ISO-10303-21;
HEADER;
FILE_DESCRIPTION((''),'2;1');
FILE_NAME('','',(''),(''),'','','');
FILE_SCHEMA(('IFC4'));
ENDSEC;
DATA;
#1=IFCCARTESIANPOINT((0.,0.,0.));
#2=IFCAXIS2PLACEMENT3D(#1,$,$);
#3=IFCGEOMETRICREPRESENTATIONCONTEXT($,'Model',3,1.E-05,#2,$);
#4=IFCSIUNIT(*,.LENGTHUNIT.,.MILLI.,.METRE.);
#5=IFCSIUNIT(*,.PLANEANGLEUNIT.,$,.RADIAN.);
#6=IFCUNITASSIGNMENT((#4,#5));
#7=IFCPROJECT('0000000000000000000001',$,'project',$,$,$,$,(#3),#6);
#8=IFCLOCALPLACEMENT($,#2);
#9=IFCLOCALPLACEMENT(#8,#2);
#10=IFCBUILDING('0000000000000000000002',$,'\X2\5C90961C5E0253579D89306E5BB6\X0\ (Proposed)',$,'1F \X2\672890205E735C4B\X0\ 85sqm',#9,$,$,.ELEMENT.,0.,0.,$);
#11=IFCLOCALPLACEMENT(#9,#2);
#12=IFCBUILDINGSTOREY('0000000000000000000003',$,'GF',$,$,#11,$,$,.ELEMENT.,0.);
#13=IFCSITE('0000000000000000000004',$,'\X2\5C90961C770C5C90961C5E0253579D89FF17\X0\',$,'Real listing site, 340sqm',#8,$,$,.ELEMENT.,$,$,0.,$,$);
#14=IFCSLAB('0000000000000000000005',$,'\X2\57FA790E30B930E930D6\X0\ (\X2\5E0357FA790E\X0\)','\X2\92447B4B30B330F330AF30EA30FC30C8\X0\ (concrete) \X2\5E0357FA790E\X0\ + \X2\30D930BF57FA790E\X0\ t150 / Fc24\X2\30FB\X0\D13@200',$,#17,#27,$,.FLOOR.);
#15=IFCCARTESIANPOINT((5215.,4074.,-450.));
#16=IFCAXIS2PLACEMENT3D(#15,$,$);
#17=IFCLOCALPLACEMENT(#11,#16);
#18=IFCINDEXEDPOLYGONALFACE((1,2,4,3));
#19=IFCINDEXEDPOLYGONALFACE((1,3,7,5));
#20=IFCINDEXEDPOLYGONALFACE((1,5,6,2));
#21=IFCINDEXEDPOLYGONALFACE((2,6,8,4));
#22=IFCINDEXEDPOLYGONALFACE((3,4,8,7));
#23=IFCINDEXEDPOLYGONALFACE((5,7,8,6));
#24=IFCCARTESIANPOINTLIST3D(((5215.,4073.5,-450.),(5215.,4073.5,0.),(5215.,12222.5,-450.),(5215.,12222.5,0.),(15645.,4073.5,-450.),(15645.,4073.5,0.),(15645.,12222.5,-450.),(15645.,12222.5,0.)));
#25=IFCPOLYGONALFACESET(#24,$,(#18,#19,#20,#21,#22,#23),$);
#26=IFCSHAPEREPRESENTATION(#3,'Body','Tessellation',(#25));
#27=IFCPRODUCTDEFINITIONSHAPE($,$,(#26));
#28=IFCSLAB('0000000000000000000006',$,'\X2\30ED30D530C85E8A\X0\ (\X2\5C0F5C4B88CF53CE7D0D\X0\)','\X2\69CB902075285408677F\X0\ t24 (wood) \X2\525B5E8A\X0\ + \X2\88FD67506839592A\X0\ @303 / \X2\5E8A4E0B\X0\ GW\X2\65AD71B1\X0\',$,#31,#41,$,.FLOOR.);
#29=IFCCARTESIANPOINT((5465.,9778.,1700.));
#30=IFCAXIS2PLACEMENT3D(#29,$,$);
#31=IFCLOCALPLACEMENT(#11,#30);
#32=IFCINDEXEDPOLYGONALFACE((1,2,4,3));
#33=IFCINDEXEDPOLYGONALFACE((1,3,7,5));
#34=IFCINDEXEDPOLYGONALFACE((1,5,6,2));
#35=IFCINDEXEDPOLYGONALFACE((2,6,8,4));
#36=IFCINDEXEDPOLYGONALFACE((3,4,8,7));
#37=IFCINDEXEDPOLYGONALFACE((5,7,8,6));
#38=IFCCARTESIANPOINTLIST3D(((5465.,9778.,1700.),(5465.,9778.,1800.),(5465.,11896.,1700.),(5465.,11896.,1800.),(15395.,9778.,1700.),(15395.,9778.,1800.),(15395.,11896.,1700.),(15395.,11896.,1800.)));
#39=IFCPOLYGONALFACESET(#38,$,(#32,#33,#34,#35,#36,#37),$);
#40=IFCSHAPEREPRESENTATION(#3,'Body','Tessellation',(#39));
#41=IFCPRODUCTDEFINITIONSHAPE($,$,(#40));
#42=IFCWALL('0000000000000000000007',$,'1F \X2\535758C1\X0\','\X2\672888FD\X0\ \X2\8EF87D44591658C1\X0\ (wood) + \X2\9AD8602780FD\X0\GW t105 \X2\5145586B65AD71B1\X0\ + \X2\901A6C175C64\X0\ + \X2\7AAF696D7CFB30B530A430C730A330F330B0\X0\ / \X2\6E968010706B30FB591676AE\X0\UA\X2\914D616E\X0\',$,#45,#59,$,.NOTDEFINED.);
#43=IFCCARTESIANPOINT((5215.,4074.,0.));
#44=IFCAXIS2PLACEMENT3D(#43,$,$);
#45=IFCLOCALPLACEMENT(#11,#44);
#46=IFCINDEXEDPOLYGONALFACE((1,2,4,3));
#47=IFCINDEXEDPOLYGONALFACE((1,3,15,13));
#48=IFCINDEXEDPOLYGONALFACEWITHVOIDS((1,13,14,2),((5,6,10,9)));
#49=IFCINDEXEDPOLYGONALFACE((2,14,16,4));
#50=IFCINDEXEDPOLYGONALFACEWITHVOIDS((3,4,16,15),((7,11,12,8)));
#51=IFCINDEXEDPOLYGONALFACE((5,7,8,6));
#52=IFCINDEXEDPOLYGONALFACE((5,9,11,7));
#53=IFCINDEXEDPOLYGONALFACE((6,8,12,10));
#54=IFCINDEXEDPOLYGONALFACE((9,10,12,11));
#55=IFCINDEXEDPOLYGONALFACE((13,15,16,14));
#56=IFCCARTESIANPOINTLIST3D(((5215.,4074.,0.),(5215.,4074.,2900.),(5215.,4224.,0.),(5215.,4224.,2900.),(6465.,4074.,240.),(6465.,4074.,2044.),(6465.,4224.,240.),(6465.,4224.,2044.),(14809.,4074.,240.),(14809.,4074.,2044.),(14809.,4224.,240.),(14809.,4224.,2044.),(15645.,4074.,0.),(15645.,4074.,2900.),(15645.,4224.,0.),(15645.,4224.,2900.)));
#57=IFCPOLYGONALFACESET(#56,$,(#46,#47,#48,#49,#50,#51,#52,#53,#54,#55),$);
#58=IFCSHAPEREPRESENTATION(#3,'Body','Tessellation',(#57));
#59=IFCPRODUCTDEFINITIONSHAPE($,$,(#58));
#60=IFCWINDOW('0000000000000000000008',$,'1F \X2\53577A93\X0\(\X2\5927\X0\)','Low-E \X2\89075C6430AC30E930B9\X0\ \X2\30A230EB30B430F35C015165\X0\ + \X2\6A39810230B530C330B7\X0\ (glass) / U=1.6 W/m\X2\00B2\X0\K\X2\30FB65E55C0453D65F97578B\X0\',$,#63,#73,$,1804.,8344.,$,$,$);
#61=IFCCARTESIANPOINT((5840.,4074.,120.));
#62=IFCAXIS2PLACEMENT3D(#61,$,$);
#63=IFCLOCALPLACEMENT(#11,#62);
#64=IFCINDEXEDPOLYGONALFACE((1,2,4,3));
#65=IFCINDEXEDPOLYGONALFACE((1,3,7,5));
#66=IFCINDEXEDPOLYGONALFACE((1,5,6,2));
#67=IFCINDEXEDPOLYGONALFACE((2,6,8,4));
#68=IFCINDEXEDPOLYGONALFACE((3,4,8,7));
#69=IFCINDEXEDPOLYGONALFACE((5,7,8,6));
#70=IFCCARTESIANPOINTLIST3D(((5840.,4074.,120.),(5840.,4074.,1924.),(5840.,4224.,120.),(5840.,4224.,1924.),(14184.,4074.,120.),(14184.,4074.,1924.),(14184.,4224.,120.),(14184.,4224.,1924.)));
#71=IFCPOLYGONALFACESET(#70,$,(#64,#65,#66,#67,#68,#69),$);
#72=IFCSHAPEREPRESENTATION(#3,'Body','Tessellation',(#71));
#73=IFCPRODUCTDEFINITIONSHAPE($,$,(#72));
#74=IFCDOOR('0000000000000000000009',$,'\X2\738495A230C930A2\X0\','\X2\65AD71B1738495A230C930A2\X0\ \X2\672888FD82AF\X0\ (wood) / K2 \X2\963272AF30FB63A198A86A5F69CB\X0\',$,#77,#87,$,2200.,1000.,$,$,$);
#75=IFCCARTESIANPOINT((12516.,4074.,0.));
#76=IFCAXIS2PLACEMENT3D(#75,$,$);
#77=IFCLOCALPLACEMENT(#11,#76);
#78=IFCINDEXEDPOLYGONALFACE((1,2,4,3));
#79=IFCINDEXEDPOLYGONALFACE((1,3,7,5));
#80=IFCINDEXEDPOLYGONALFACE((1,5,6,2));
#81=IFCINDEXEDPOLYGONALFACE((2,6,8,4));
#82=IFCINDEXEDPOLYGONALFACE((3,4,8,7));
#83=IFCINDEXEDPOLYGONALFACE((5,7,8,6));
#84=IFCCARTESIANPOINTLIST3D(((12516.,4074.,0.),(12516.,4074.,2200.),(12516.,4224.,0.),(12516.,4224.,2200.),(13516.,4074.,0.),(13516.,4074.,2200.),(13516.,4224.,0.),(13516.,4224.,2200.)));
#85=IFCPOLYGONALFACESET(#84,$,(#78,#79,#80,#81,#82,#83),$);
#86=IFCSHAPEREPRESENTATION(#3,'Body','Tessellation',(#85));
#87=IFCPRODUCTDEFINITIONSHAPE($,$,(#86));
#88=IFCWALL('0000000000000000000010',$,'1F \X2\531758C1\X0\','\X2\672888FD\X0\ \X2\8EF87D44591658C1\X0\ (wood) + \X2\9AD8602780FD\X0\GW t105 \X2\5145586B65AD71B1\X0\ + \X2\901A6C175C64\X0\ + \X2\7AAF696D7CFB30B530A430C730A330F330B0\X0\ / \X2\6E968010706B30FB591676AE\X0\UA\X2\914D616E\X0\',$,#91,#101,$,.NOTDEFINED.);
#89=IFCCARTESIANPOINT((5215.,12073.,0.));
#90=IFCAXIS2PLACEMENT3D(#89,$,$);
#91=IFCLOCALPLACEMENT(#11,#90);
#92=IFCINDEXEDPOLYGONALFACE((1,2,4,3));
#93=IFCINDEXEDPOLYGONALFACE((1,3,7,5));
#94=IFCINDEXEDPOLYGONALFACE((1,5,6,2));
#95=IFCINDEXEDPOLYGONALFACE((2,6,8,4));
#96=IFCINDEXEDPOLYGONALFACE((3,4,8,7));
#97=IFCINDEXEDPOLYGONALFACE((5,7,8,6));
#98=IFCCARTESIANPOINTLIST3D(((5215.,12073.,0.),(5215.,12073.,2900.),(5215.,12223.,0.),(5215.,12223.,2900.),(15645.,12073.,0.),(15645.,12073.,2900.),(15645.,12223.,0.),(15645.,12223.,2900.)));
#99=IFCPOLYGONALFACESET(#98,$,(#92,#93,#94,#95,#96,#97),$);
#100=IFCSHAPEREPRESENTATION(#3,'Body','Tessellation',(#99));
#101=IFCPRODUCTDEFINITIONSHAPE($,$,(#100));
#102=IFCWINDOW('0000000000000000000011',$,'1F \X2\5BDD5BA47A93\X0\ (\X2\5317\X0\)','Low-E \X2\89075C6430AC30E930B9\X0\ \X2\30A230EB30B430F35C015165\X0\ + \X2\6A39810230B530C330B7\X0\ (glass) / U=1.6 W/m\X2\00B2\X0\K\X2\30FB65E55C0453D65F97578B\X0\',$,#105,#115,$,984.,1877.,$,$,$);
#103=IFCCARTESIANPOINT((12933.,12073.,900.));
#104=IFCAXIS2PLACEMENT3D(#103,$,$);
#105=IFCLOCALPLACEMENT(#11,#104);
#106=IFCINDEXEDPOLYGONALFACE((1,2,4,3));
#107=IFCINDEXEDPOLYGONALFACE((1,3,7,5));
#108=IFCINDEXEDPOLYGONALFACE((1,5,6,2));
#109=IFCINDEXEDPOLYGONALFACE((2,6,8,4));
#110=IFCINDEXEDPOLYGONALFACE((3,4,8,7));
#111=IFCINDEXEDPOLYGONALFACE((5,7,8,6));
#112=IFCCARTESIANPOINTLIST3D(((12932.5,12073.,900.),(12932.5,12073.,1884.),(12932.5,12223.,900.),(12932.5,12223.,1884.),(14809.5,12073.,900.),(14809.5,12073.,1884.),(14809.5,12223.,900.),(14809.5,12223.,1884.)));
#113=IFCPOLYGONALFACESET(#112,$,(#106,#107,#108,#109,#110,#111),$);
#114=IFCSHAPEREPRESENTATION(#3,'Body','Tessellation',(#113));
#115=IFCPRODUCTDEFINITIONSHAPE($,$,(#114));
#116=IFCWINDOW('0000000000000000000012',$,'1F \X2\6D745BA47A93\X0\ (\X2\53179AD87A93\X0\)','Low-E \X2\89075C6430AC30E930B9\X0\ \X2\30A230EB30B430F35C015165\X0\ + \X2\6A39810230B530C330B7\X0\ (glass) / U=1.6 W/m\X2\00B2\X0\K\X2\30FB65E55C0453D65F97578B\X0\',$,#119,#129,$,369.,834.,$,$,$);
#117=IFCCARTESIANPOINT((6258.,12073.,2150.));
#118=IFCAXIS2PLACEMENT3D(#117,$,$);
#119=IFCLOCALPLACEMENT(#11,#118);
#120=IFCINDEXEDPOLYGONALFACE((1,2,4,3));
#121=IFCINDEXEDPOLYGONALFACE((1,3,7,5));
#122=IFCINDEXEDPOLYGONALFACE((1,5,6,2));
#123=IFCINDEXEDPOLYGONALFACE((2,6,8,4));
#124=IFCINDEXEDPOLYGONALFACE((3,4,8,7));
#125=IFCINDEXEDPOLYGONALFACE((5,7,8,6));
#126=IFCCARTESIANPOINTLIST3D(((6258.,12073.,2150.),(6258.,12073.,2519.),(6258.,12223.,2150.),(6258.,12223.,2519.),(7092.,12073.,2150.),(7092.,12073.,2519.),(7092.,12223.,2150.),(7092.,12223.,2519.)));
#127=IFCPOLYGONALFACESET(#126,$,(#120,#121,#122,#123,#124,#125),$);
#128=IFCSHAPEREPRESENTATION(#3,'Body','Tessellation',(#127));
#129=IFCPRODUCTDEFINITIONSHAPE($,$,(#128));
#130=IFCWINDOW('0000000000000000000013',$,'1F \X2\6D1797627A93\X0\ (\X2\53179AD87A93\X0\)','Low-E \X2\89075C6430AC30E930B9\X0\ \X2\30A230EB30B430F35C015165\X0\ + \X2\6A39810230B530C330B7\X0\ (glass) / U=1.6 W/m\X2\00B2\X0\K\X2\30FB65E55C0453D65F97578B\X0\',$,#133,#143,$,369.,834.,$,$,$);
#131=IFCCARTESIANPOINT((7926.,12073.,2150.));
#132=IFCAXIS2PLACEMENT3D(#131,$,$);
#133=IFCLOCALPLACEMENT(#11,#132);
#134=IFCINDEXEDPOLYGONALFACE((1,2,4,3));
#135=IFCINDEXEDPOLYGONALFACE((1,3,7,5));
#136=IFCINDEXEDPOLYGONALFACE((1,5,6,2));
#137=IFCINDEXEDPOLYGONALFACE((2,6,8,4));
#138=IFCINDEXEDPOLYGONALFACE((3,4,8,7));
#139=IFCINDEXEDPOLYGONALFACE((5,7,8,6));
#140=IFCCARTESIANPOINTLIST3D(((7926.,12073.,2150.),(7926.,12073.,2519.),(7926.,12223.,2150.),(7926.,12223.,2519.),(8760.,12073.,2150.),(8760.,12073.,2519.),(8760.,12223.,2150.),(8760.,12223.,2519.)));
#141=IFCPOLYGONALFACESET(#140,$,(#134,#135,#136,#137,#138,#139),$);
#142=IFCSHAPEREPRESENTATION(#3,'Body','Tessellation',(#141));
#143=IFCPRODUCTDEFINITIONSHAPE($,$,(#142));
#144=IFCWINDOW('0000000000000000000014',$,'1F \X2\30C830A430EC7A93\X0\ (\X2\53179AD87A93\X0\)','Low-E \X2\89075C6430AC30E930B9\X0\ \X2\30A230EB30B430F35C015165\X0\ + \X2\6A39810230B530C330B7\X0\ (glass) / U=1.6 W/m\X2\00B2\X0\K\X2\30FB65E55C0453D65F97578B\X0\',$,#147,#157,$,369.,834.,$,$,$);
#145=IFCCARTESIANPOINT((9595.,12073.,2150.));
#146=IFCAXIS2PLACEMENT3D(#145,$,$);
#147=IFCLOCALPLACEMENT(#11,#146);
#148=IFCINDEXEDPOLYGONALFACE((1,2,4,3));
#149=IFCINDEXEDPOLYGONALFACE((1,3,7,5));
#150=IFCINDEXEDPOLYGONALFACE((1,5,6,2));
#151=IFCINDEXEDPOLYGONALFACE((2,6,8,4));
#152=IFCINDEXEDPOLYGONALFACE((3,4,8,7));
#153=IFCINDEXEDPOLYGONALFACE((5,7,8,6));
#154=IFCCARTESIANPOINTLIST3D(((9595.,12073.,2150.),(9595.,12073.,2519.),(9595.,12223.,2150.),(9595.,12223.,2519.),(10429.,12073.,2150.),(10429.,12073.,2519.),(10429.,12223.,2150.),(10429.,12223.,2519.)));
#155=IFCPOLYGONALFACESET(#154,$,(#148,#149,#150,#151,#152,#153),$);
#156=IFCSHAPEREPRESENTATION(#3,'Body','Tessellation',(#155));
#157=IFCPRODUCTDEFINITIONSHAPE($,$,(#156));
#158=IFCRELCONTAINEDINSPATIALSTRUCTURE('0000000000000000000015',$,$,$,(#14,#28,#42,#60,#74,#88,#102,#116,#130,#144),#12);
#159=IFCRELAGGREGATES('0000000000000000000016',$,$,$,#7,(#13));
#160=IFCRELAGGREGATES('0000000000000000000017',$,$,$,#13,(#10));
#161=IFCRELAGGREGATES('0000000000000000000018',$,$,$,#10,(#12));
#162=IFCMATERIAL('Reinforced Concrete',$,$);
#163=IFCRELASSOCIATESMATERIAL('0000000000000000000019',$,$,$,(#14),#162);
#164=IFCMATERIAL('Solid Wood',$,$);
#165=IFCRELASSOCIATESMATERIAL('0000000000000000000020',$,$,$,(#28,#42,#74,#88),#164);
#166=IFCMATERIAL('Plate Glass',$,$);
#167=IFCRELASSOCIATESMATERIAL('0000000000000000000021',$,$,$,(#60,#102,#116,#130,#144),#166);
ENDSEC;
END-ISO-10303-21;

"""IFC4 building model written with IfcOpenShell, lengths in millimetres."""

from ifc_helpers import new_model, si_unit, frame, frame_2d, origin, place, context, project, spatial, rectangle, extrude, material, element, fill, save


model = new_model("IFC4")

# Units and contexts
model_context = context("Model", 3, precision=1e-05, world=origin())
ifc_project = project(units=[si_unit("LENGTHUNIT", "METRE", prefix="MILLI"), si_unit("PLANEANGLEUNIT", "RADIAN")], contexts=[model_context])

# Site, building, storey
site_placement = place(None, origin())
site = spatial("IfcSite", under=ifc_project, at=site_placement, Name="岐阜県岐阜市南鶉７", ObjectType="Real listing site, 340sqm", CompositionType="ELEMENT", RefElevation=0.0)
building_placement = place(site_placement, origin())
building = spatial("IfcBuilding", under=site, at=building_placement, Name="岐阜市南鶉の家 (Proposed)", ObjectType="1F 木造平屋 85sqm", CompositionType="ELEMENT", ElevationOfRefHeight=0.0, ElevationOfTerrain=0.0)
storey_placement = place(building_placement, origin())
storey = spatial("IfcBuildingStorey", under=building, at=storey_placement, Name="GF", CompositionType="ELEMENT", Elevation=0.0)

# Slabs
ifc_material_1 = material(Name="Reinforced Concrete")
slab_1_placement = place(storey_placement, frame((5215.0, 4074.0, -450.0)))
element("IfcSlab", 1, at=slab_1_placement, inside=storey, material=ifc_material_1, Name="基礎スラブ (布基礎)", Description="鉄筋コンクリート (concrete) 布基礎 + ベタ基礎 t150 / Fc24・D13@200", PredefinedType="FLOOR", context=model_context, shape_type="SweptSolid", body=[
    extrude(rectangle(XDim=10430.0, YDim=8149.0, at=frame_2d((5215.0, 4074.0))), frame((5215.0, 4074.0, -450.0)), (0.0, 0.0, 1.0), 450.0),
])
ifc_material_2 = material(Name="Solid Wood")
slab_2_placement = place(storey_placement, frame((5465.0, 9778.0, 1700.0)))
element("IfcSlab", 2, at=slab_2_placement, inside=storey, material=ifc_material_2, Name="ロフト床 (小屋裏収納)", Description="構造用合板 t24 (wood) 剛床 + 製材根太 @303 / 床下 GW断熱", PredefinedType="FLOOR", context=model_context, shape_type="SweptSolid", body=[
    extrude(rectangle(XDim=9930.0, YDim=2118.0, at=frame_2d((4965.0, 1059.0))), frame((5465.0, 9778.0, 1700.0)), (0.0, 0.0, 1.0), 100.0),
])

# Wall, openings, window, door
wall_1_placement = place(storey_placement, frame((5215.0, 4074.0, 0.0)))
wall_1 = element("IfcWall", 3, at=wall_1_placement, inside=storey, material=ifc_material_2, Name="1F 南壁", Description="木製 軸組外壁 (wood) + 高性能GW t105 充填断熱 + 通気層 + 窯業系サイディング / 準耐火・外皮UA配慮", PredefinedType="NOTDEFINED", context=model_context, shape_type="SweptSolid", body=[
    extrude(rectangle(XDim=10430.0, YDim=150.0, at=frame_2d((5215.0, 75.0))), frame((5215.0, 4074.0, 0.0)), (0.0, 0.0, 1.0), 2900.0),
])
opening_1_placement = place(storey_placement, frame((5840.0, 4074.0, 120.0)))
opening_1 = element("IfcOpeningElement", 4, at=opening_1_placement, cuts=wall_1, PredefinedType="NOTDEFINED", context=model_context, shape_type="SweptSolid", body=[
    extrude(rectangle(XDim=8344.0, YDim=150.0, at=frame_2d((4172.0, 75.0))), frame((5840.0, 4074.0, 120.0)), (0.0, 0.0, 1.0), 1804.0),
])
opening_2_placement = place(storey_placement, frame((12516.0, 4074.0, 0.0)))
opening_2 = element("IfcOpeningElement", 5, at=opening_2_placement, cuts=wall_1, PredefinedType="NOTDEFINED", context=model_context, shape_type="SweptSolid", body=[
    extrude(rectangle(XDim=1000.0, YDim=150.0, at=frame_2d((500.0, 75.0))), frame((12516.0, 4074.0, 0.0)), (0.0, 0.0, 1.0), 2200.0),
])
ifc_material_3 = material(Name="Plate Glass")
window_1_placement = place(storey_placement, frame((5840.0, 4074.0, 120.0)))
window_1 = element("IfcWindow", 6, at=window_1_placement, inside=storey, material=ifc_material_3, Name="1F 南窓(大)", Description="Low-E 複層ガラス アルゴン封入 + 樹脂サッシ (glass) / U=1.6 W/m²K・日射取得型", OverallHeight=1804.0, OverallWidth=8344.0, context=model_context, shape_type="SweptSolid", body=[
    extrude(rectangle(XDim=8344.0, YDim=150.0, at=frame_2d((4172.0, 75.0))), frame((5840.0, 4074.0, 120.0)), (0.0, 0.0, 1.0), 1804.0),
])
fill(opening_1, window_1)
door_1_placement = place(storey_placement, frame((12516.0, 4074.0, 0.0)))
door_1 = element("IfcDoor", 7, at=door_1_placement, inside=storey, material=ifc_material_2, Name="玄関ドア", Description="断熱玄関ドア 木製芯 (wood) / K2 防犯・採風機構", OverallHeight=2200.0, OverallWidth=1000.0, context=model_context, shape_type="SweptSolid", body=[
    extrude(rectangle(XDim=1000.0, YDim=150.0, at=frame_2d((500.0, 75.0))), frame((12516.0, 4074.0, 0.0)), (0.0, 0.0, 1.0), 2200.0),
])
fill(opening_2, door_1)

# Wall, openings, windows
wall_2_placement = place(storey_placement, frame((5215.0, 12073.0, 0.0)))
wall_2 = element("IfcWall", 8, at=wall_2_placement, inside=storey, material=ifc_material_2, Name="1F 北壁", Description="木製 軸組外壁 (wood) + 高性能GW t105 充填断熱 + 通気層 + 窯業系サイディング / 準耐火・外皮UA配慮", PredefinedType="NOTDEFINED", context=model_context, shape_type="SweptSolid", body=[
    extrude(rectangle(XDim=10430.0, YDim=150.0, at=frame_2d((5215.0, 75.0))), frame((5215.0, 12073.0, 0.0)), (0.0, 0.0, 1.0), 2900.0),
])
opening_3_placement = place(storey_placement, frame((12933.0, 12073.0, 900.0)))
opening_3 = element("IfcOpeningElement", 9, at=opening_3_placement, cuts=wall_2, PredefinedType="NOTDEFINED", context=model_context, shape_type="SweptSolid", body=[
    extrude(rectangle(XDim=1877.0, YDim=150.0, at=frame_2d((938.0, 75.0))), frame((12933.0, 12073.0, 900.0)), (0.0, 0.0, 1.0), 984.0),
])
opening_4_placement = place(storey_placement, frame((6258.0, 12073.0, 2150.0)))
opening_4 = element("IfcOpeningElement", 10, at=opening_4_placement, cuts=wall_2, PredefinedType="NOTDEFINED", context=model_context, shape_type="SweptSolid", body=[
    extrude(rectangle(XDim=834.0, YDim=150.0, at=frame_2d((417.0, 75.0))), frame((6258.0, 12073.0, 2150.0)), (0.0, 0.0, 1.0), 369.0),
])
opening_5_placement = place(storey_placement, frame((7926.0, 12073.0, 2150.0)))
opening_5 = element("IfcOpeningElement", 11, at=opening_5_placement, cuts=wall_2, PredefinedType="NOTDEFINED", context=model_context, shape_type="SweptSolid", body=[
    extrude(rectangle(XDim=834.0, YDim=150.0, at=frame_2d((417.0, 75.0))), frame((7926.0, 12073.0, 2150.0)), (0.0, 0.0, 1.0), 369.0),
])
opening_6_placement = place(storey_placement, frame((9595.0, 12073.0, 2150.0)))
opening_6 = element("IfcOpeningElement", 12, at=opening_6_placement, cuts=wall_2, PredefinedType="NOTDEFINED", context=model_context, shape_type="SweptSolid", body=[
    extrude(rectangle(XDim=834.0, YDim=150.0, at=frame_2d((417.0, 75.0))), frame((9595.0, 12073.0, 2150.0)), (0.0, 0.0, 1.0), 369.0),
])
window_2_placement = place(storey_placement, frame((12933.0, 12073.0, 900.0)))
window_2 = element("IfcWindow", 13, at=window_2_placement, inside=storey, material=ifc_material_3, Name="1F 寝室窓 (北)", Description="Low-E 複層ガラス アルゴン封入 + 樹脂サッシ (glass) / U=1.6 W/m²K・日射取得型", OverallHeight=984.0, OverallWidth=1877.0, context=model_context, shape_type="SweptSolid", body=[
    extrude(rectangle(XDim=1877.0, YDim=150.0, at=frame_2d((938.0, 75.0))), frame((12933.0, 12073.0, 900.0)), (0.0, 0.0, 1.0), 984.0),
])
fill(opening_3, window_2)
window_3_placement = place(storey_placement, frame((6258.0, 12073.0, 2150.0)))
window_3 = element("IfcWindow", 14, at=window_3_placement, inside=storey, material=ifc_material_3, Name="1F 浴室窓 (北高窓)", Description="Low-E 複層ガラス アルゴン封入 + 樹脂サッシ (glass) / U=1.6 W/m²K・日射取得型", OverallHeight=369.0, OverallWidth=834.0, context=model_context, shape_type="SweptSolid", body=[
    extrude(rectangle(XDim=834.0, YDim=150.0, at=frame_2d((417.0, 75.0))), frame((6258.0, 12073.0, 2150.0)), (0.0, 0.0, 1.0), 369.0),
])
fill(opening_4, window_3)
window_4_placement = place(storey_placement, frame((7926.0, 12073.0, 2150.0)))
window_4 = element("IfcWindow", 15, at=window_4_placement, inside=storey, material=ifc_material_3, Name="1F 洗面窓 (北高窓)", Description="Low-E 複層ガラス アルゴン封入 + 樹脂サッシ (glass) / U=1.6 W/m²K・日射取得型", OverallHeight=369.0, OverallWidth=834.0, context=model_context, shape_type="SweptSolid", body=[
    extrude(rectangle(XDim=834.0, YDim=150.0, at=frame_2d((417.0, 75.0))), frame((7926.0, 12073.0, 2150.0)), (0.0, 0.0, 1.0), 369.0),
])
fill(opening_5, window_4)
window_5_placement = place(storey_placement, frame((9595.0, 12073.0, 2150.0)))
window_5 = element("IfcWindow", 16, at=window_5_placement, inside=storey, material=ifc_material_3, Name="1F トイレ窓 (北高窓)", Description="Low-E 複層ガラス アルゴン封入 + 樹脂サッシ (glass) / U=1.6 W/m²K・日射取得型", OverallHeight=369.0, OverallWidth=834.0, context=model_context, shape_type="SweptSolid", body=[
    extrude(rectangle(XDim=834.0, YDim=150.0, at=frame_2d((417.0, 75.0))), frame((9595.0, 12073.0, 2150.0)), (0.0, 0.0, 1.0), 369.0),
])
fill(opening_6, window_5)

save(model, "model.ifc")
